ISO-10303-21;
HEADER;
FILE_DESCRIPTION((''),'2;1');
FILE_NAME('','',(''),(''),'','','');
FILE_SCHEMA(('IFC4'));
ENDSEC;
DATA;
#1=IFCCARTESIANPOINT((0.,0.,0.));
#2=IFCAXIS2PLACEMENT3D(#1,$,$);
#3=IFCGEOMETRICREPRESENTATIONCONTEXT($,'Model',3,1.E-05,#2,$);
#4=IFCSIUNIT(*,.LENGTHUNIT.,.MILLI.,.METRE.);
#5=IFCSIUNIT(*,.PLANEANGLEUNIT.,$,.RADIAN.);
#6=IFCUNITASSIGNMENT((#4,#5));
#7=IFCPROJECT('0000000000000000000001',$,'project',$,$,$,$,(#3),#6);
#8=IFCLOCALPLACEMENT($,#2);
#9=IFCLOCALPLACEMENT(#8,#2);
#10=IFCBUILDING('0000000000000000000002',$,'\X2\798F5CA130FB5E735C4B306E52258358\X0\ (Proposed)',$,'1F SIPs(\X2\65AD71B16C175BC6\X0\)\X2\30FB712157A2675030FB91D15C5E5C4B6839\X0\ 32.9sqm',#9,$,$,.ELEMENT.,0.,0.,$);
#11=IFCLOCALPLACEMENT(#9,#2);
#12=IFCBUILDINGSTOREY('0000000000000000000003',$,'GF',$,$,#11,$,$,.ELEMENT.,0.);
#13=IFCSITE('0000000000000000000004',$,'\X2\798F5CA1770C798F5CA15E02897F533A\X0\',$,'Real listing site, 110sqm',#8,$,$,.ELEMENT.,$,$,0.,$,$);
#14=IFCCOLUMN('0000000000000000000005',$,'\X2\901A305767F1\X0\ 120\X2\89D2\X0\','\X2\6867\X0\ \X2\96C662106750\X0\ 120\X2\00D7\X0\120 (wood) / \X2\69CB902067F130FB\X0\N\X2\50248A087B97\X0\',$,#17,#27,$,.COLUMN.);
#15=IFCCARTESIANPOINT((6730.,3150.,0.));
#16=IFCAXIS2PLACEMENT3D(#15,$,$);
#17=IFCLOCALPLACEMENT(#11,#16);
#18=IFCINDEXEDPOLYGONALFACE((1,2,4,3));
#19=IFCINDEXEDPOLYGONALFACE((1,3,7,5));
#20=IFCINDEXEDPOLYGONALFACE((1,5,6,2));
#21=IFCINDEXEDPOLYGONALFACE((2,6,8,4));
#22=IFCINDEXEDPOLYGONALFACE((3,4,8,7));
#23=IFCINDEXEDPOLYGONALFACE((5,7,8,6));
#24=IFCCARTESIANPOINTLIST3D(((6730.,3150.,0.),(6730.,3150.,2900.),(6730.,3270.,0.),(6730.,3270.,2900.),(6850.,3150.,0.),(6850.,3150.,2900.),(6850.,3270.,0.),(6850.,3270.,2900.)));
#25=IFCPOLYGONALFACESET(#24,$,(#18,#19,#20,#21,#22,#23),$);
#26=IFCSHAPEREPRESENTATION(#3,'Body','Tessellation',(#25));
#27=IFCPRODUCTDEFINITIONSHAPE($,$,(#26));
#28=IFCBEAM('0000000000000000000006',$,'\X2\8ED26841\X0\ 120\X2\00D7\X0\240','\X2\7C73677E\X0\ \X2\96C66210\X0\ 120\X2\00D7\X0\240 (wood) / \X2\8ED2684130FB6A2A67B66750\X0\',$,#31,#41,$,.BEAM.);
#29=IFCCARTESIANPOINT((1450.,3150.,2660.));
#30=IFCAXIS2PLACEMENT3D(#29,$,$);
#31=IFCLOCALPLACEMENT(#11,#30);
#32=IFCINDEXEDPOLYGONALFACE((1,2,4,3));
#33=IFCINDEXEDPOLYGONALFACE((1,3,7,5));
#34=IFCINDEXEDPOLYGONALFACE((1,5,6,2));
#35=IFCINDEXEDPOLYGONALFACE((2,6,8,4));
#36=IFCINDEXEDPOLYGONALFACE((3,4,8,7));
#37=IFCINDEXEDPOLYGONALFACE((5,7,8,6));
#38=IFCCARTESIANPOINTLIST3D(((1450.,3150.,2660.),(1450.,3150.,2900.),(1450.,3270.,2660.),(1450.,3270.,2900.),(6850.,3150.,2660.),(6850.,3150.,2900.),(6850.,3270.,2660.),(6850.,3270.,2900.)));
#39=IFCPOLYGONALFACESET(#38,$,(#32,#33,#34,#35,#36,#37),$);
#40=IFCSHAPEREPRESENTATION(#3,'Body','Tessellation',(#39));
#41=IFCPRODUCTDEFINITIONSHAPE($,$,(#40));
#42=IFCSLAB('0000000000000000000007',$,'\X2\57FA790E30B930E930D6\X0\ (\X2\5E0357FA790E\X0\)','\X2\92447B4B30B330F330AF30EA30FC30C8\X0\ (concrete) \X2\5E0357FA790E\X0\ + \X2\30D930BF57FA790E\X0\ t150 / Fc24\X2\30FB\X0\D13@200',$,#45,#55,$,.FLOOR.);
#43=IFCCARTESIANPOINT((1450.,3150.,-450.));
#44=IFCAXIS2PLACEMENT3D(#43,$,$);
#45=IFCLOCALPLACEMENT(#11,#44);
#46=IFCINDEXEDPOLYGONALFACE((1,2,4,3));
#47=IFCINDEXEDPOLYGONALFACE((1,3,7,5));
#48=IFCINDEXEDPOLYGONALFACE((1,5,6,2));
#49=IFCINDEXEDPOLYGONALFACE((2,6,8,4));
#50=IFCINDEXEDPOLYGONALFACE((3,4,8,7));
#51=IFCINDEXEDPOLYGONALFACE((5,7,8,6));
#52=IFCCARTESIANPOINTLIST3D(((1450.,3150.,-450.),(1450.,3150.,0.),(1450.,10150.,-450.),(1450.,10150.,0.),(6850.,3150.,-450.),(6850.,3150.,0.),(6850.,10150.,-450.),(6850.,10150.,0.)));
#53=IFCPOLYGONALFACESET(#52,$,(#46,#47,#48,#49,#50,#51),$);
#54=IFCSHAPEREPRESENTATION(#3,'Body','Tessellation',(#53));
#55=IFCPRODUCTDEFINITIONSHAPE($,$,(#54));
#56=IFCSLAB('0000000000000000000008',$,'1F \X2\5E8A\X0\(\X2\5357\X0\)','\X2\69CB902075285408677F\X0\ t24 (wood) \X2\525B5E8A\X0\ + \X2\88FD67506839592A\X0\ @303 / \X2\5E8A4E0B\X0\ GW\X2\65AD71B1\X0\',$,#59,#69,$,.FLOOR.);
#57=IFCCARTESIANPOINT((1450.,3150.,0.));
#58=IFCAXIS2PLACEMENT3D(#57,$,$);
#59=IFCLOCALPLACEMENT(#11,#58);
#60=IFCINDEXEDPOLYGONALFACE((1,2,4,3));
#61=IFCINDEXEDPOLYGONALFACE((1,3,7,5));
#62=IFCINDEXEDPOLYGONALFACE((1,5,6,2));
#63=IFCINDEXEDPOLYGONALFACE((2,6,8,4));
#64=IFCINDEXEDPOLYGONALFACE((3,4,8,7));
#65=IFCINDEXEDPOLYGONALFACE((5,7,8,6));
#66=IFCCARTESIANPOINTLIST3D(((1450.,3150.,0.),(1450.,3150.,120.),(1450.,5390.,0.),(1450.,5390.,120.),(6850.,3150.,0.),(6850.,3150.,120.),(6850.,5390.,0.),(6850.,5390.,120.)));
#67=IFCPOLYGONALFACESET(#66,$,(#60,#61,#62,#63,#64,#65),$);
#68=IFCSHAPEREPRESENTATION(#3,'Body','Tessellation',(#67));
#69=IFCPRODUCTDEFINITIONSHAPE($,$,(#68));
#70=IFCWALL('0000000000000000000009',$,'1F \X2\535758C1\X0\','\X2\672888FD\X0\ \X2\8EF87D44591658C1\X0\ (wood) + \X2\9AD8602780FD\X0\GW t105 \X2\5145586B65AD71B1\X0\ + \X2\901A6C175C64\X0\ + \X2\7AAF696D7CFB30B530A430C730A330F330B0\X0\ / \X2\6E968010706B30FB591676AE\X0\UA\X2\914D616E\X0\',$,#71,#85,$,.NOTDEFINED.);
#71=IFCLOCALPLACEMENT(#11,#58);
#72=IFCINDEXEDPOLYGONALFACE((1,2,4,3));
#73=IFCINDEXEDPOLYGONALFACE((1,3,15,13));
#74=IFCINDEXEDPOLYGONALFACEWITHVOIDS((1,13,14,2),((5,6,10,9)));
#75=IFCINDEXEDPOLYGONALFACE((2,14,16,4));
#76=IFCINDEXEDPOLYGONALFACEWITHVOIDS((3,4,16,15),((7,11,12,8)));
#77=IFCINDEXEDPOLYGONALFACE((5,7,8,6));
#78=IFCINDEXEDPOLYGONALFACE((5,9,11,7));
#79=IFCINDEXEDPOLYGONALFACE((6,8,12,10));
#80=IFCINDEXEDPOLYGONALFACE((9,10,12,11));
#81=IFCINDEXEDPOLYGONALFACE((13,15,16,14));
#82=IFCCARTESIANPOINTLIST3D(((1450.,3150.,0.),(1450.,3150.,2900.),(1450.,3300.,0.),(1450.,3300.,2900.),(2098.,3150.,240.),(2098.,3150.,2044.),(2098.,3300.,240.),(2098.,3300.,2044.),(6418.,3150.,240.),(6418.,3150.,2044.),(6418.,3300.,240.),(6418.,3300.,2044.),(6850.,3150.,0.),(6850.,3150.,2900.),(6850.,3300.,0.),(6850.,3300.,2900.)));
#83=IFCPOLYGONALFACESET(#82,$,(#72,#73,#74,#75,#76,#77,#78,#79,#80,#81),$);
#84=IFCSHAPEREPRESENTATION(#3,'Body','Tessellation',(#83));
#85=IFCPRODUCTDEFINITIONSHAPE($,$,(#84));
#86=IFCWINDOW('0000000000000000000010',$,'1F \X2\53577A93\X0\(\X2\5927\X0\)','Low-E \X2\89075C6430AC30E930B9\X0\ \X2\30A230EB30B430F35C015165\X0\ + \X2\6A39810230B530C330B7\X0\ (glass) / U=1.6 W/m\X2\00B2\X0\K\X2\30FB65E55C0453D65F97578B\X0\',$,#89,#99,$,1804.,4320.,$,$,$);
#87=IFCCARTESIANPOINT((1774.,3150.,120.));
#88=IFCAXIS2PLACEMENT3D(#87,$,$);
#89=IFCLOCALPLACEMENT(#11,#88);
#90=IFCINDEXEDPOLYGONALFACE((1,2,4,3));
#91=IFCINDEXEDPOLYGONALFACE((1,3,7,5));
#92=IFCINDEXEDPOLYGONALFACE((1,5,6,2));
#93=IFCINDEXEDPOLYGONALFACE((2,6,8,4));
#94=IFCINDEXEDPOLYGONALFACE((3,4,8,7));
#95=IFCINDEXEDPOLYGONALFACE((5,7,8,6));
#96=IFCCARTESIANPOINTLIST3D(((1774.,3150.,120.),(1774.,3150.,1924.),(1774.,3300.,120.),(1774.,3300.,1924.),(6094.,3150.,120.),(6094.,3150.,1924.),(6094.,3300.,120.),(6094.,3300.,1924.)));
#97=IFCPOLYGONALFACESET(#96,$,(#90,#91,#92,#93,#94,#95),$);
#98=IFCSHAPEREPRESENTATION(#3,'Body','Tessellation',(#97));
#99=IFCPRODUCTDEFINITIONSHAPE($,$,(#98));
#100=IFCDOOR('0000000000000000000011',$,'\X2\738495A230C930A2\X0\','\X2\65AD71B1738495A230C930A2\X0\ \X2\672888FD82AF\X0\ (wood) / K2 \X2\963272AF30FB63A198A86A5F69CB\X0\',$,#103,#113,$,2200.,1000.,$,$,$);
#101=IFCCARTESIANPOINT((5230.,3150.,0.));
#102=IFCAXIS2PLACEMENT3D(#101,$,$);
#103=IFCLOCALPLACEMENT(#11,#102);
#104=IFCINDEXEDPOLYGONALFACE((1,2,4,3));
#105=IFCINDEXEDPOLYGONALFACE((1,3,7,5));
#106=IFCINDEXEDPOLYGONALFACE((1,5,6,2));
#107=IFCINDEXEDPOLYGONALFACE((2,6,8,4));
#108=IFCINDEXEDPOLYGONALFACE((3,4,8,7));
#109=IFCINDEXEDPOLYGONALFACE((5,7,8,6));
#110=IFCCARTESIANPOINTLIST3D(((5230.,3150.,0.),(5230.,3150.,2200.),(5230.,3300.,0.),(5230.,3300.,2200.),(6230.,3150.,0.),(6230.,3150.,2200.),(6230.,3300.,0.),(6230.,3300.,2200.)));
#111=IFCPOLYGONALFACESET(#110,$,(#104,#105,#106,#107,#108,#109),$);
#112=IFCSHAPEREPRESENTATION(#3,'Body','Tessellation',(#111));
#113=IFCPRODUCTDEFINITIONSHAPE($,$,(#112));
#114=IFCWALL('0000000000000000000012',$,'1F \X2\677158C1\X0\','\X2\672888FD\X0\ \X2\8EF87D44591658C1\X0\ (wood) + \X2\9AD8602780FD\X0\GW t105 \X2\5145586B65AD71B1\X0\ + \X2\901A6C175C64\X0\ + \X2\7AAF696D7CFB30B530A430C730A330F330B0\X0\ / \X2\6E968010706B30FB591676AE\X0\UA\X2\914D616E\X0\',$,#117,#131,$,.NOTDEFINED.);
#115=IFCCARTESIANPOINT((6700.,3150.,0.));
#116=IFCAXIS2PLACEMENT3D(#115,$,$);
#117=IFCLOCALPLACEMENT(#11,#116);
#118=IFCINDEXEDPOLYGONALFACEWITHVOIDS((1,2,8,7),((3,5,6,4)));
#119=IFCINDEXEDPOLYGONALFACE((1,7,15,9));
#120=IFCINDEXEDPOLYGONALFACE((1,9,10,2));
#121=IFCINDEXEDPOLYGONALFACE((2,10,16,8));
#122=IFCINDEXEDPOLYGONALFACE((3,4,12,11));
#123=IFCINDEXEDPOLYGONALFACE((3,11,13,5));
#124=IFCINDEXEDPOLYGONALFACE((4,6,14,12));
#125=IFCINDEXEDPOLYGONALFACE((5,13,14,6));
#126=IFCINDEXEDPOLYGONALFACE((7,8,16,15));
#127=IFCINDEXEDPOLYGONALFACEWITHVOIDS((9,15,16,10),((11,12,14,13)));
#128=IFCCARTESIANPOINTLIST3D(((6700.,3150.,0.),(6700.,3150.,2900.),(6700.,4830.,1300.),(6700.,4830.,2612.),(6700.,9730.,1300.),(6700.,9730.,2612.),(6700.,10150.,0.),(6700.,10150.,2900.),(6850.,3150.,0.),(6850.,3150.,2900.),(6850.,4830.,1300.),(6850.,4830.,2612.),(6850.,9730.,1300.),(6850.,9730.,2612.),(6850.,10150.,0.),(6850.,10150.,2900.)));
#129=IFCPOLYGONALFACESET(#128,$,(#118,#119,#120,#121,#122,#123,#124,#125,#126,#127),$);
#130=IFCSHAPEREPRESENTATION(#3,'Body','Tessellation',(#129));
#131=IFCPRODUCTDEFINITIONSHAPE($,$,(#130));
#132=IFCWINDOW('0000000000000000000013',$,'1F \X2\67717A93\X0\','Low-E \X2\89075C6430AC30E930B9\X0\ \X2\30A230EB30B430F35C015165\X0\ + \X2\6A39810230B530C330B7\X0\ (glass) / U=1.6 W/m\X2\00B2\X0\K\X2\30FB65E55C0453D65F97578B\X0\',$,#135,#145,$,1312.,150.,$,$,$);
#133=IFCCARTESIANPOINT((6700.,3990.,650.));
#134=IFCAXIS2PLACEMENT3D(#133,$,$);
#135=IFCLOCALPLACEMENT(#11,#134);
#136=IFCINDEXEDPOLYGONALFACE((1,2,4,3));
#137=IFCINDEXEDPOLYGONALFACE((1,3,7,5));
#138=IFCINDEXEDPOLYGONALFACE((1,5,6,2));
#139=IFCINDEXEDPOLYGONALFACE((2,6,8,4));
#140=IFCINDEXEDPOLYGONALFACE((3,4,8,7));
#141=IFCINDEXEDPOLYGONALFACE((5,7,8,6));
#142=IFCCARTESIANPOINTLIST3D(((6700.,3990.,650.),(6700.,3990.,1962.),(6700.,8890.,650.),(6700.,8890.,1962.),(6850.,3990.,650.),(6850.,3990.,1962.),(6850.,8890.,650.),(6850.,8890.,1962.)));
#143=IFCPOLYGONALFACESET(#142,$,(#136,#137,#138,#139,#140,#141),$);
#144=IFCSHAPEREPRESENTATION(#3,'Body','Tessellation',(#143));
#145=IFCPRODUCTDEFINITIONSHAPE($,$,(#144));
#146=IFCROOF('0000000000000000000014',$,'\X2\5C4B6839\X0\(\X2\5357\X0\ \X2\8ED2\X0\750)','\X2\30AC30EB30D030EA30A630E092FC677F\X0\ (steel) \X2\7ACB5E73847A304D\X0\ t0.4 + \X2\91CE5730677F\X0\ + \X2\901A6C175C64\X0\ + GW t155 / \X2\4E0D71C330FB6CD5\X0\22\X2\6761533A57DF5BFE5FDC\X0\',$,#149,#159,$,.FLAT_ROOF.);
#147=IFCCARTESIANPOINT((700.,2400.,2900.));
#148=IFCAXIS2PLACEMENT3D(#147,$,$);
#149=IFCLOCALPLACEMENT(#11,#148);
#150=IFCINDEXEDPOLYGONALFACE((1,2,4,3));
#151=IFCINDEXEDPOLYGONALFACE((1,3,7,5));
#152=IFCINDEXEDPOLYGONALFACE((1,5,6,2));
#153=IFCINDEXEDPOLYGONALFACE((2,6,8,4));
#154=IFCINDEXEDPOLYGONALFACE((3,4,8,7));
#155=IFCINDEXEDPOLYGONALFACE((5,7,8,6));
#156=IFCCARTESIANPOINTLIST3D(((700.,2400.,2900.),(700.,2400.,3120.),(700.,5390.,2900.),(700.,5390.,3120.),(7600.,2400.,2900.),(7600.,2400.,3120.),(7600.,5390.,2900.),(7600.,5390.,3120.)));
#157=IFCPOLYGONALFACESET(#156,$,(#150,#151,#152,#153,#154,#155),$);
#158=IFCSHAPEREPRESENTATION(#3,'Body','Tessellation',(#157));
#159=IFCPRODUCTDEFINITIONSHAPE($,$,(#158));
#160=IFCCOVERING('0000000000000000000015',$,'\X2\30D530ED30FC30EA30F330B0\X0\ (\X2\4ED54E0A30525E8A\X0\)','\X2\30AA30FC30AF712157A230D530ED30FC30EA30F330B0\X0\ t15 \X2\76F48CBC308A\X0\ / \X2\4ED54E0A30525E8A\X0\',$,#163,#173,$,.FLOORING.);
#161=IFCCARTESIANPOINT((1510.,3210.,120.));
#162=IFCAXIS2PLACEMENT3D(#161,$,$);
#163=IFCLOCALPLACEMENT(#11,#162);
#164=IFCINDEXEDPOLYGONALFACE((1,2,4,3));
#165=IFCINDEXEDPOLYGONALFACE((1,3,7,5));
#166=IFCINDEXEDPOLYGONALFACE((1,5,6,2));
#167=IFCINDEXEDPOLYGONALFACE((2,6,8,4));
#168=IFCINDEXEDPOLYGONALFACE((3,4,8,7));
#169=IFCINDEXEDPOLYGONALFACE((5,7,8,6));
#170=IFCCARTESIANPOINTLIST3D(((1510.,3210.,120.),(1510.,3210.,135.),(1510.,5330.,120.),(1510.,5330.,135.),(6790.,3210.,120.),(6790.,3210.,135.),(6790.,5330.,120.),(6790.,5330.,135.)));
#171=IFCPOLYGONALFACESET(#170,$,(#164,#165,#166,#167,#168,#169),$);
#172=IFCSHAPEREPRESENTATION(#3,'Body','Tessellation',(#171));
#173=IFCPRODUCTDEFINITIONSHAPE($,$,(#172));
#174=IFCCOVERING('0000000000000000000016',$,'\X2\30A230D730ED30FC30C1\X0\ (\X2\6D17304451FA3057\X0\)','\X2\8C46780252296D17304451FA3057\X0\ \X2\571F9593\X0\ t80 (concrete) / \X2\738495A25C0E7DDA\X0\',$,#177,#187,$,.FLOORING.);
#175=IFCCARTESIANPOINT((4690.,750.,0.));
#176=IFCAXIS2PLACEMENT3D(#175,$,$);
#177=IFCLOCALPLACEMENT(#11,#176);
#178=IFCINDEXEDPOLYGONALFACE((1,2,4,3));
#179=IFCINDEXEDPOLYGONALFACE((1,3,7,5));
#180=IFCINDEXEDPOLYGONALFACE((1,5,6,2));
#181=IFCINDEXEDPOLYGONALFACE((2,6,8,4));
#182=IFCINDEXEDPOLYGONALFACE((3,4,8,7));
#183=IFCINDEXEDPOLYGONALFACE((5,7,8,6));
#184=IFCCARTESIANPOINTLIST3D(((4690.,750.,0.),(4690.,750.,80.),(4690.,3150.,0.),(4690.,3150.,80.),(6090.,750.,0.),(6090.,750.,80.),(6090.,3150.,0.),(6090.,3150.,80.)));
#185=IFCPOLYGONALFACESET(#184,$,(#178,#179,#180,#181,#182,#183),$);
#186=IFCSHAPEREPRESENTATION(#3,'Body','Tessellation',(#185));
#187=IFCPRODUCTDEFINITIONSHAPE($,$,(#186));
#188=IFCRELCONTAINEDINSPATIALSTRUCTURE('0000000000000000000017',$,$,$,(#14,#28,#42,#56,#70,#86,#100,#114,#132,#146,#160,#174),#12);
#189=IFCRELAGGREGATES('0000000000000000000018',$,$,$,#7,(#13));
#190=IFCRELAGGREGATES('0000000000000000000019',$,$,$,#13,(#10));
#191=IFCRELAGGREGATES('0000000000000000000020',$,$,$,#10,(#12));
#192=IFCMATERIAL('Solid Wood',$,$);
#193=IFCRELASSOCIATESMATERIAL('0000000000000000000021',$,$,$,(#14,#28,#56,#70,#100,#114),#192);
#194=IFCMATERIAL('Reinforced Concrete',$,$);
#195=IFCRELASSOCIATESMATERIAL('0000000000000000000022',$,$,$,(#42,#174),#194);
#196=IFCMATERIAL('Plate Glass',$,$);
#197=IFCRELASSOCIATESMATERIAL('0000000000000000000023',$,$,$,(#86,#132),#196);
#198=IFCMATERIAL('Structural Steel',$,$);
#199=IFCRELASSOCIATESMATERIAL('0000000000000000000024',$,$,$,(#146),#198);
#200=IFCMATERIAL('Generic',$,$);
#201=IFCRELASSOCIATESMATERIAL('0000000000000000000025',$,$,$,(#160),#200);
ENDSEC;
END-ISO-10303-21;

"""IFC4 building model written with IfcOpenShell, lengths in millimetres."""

from ifc_helpers import new_model, si_unit, frame, frame_2d, origin, place, context, project, spatial, rectangle, extrude, material, element, fill, save


model = new_model("IFC4")

# Units and contexts
model_context = context("Model", 3, precision=1e-05, world=origin())
ifc_project = project(units=[si_unit("LENGTHUNIT", "METRE", prefix="MILLI"), si_unit("PLANEANGLEUNIT", "RADIAN")], contexts=[model_context])

# Site, building, storey
site_placement = place(None, origin())
site = spatial("IfcSite", under=ifc_project, at=site_placement, Name="福岡県福岡市西区", ObjectType="Real listing site, 110sqm", CompositionType="ELEMENT", RefElevation=0.0)
building_placement = place(site_placement, origin())
building = spatial("IfcBuilding", under=site, at=building_placement, Name="福岡・平屋の別荘 (Proposed)", ObjectType="1F SIPs(断熱気密)・無垢材・金属屋根 32.9sqm", CompositionType="ELEMENT", ElevationOfRefHeight=0.0, ElevationOfTerrain=0.0)
storey_placement = place(building_placement, origin())
storey = spatial("IfcBuildingStorey", under=building, at=storey_placement, Name="GF", CompositionType="ELEMENT", Elevation=0.0)

# Column
ifc_material_1 = material(Name="Solid Wood")
column_1_placement = place(storey_placement, frame((6730.0, 3150.0, 0.0)))
element("IfcColumn", 1, at=column_1_placement, inside=storey, material=ifc_material_1, Name="通し柱 120角", Description="桧 集成材 120×120 (wood) / 構造柱・N値計算", PredefinedType="COLUMN", context=model_context, shape_type="SweptSolid", body=[
    extrude(rectangle(XDim=120.0, YDim=120.0, at=frame_2d((60.0, 60.0))), frame((6730.0, 3150.0, 0.0)), (0.0, 0.0, 1.0), 2900.0),
])

# Beam
beam_1_placement = place(storey_placement, frame((1450.0, 3150.0, 2660.0)))
element("IfcBeam", 2, at=beam_1_placement, inside=storey, material=ifc_material_1, Name="軒桁 120×240", Description="米松 集成 120×240 (wood) / 軒桁・横架材", PredefinedType="BEAM", context=model_context, shape_type="SweptSolid", body=[
    extrude(rectangle(XDim=5400.0, YDim=120.0, at=frame_2d((2700.0, 60.0))), frame((1450.0, 3150.0, 2660.0)), (0.0, 0.0, 1.0), 240.0),
])

# Slabs
ifc_material_2 = material(Name="Reinforced Concrete")
slab_1_placement = place(storey_placement, frame((1450.0, 3150.0, -450.0)))
element("IfcSlab", 3, at=slab_1_placement, inside=storey, material=ifc_material_2, Name="基礎スラブ (布基礎)", Description="鉄筋コンクリート (concrete) 布基礎 + ベタ基礎 t150 / Fc24・D13@200", PredefinedType="FLOOR", context=model_context, shape_type="SweptSolid", body=[
    extrude(rectangle(XDim=5400.0, YDim=7000.0, at=frame_2d((2700.0, 3500.0))), frame((1450.0, 3150.0, -450.0)), (0.0, 0.0, 1.0), 450.0),
])
slab_2_placement = place(storey_placement, frame((1450.0, 3150.0, 0.0)))
element("IfcSlab", 4, at=slab_2_placement, inside=storey, material=ifc_material_1, Name="1F 床(南)", Description="構造用合板 t24 (wood) 剛床 + 製材根太 @303 / 床下 GW断熱", PredefinedType="FLOOR", context=model_context, shape_type="SweptSolid", body=[
    extrude(rectangle(XDim=5400.0, YDim=2240.0, at=frame_2d((2700.0, 1120.0))), frame((1450.0, 3150.0, 0.0)), (0.0, 0.0, 1.0), 120.0),
])

# Wall, openings, window, door
wall_1_placement = place(storey_placement, frame((1450.0, 3150.0, 0.0)))
wall_1 = element("IfcWall", 5, at=wall_1_placement, inside=storey, material=ifc_material_1, Name="1F 南壁", Description="木製 軸組外壁 (wood) + 高性能GW t105 充填断熱 + 通気層 + 窯業系サイディング / 準耐火・外皮UA配慮", PredefinedType="NOTDEFINED", context=model_context, shape_type="SweptSolid", body=[
    extrude(rectangle(XDim=5400.0, YDim=150.0, at=frame_2d((2700.0, 75.0))), frame((1450.0, 3150.0, 0.0)), (0.0, 0.0, 1.0), 2900.0),
])
opening_1_placement = place(storey_placement, frame((1774.0, 3150.0, 120.0)))
opening_1 = element("IfcOpeningElement", 6, at=opening_1_placement, cuts=wall_1, PredefinedType="NOTDEFINED", context=model_context, shape_type="SweptSolid", body=[
    extrude(rectangle(XDim=4320.0, YDim=150.0, at=frame_2d((2160.0, 75.0))), frame((1774.0, 3150.0, 120.0)), (0.0, 0.0, 1.0), 1804.0),
])
opening_2_placement = place(storey_placement, frame((5230.0, 3150.0, 0.0)))
opening_2 = element("IfcOpeningElement", 7, at=opening_2_placement, cuts=wall_1, PredefinedType="NOTDEFINED", context=model_context, shape_type="SweptSolid", body=[
    extrude(rectangle(XDim=1000.0, YDim=150.0, at=frame_2d((500.0, 75.0))), frame((5230.0, 3150.0, 0.0)), (0.0, 0.0, 1.0), 2200.0),
])
ifc_material_3 = material(Name="Plate Glass")
window_1_placement = place(storey_placement, frame((1774.0, 3150.0, 120.0)))
window_1 = element("IfcWindow", 8, at=window_1_placement, inside=storey, material=ifc_material_3, Name="1F 南窓(大)", Description="Low-E 複層ガラス アルゴン封入 + 樹脂サッシ (glass) / U=1.6 W/m²K・日射取得型", OverallHeight=1804.0, OverallWidth=4320.0, context=model_context, shape_type="SweptSolid", body=[
    extrude(rectangle(XDim=4320.0, YDim=150.0, at=frame_2d((2160.0, 75.0))), frame((1774.0, 3150.0, 120.0)), (0.0, 0.0, 1.0), 1804.0),
])
fill(opening_1, window_1)
door_placement = place(storey_placement, frame((5230.0, 3150.0, 0.0)))
door = element("IfcDoor", 9, at=door_placement, inside=storey, material=ifc_material_1, Name="玄関ドア", Description="断熱玄関ドア 木製芯 (wood) / K2 防犯・採風機構", OverallHeight=2200.0, OverallWidth=1000.0, context=model_context, shape_type="SweptSolid", body=[
    extrude(rectangle(XDim=1000.0, YDim=150.0, at=frame_2d((500.0, 75.0))), frame((5230.0, 3150.0, 0.0)), (0.0, 0.0, 1.0), 2200.0),
])
fill(opening_2, door)

# Wall, opening, window
wall_2_placement = place(storey_placement, frame((6700.0, 3150.0, 0.0)))
wall_2 = element("IfcWall", 10, at=wall_2_placement, inside=storey, material=ifc_material_1, Name="1F 東壁", Description="木製 軸組外壁 (wood) + 高性能GW t105 充填断熱 + 通気層 + 窯業系サイディング / 準耐火・外皮UA配慮", PredefinedType="NOTDEFINED", context=model_context, shape_type="SweptSolid", body=[
    extrude(rectangle(XDim=150.0, YDim=7000.0, at=frame_2d((75.0, 3500.0))), frame((6700.0, 3150.0, 0.0)), (0.0, 0.0, 1.0), 2900.0),
])
opening_3_placement = place(storey_placement, frame((6700.0, 3990.0, 650.0)))
opening_3 = element("IfcOpeningElement", 11, at=opening_3_placement, cuts=wall_2, PredefinedType="NOTDEFINED", context=model_context, shape_type="SweptSolid", body=[
    extrude(rectangle(XDim=150.0, YDim=4900.0, at=frame_2d((75.0, 2450.0))), frame((6700.0, 3990.0, 650.0)), (0.0, 0.0, 1.0), 1312.0),
])
window_2_placement = place(storey_placement, frame((6700.0, 3990.0, 650.0)))
window_2 = element("IfcWindow", 12, at=window_2_placement, inside=storey, material=ifc_material_3, Name="1F 東窓", Description="Low-E 複層ガラス アルゴン封入 + 樹脂サッシ (glass) / U=1.6 W/m²K・日射取得型", OverallHeight=1312.0, OverallWidth=150.0, context=model_context, shape_type="SweptSolid", body=[
    extrude(rectangle(XDim=150.0, YDim=4900.0, at=frame_2d((75.0, 2450.0))), frame((6700.0, 3990.0, 650.0)), (0.0, 0.0, 1.0), 1312.0),
])
fill(opening_3, window_2)

# Roof
ifc_material_4 = material(Name="Structural Steel")
roof_placement = place(storey_placement, frame((700.0, 2400.0, 2900.0)))
element("IfcRoof", 13, at=roof_placement, inside=storey, material=ifc_material_4, Name="屋根(南 軒750)", Description="ガルバリウム鋼板 (steel) 立平葺き t0.4 + 野地板 + 通気層 + GW t155 / 不燃・法22条区域対応", PredefinedType="FLAT_ROOF", context=model_context, shape_type="SweptSolid", body=[
    extrude(rectangle(XDim=6900.0, YDim=2990.0, at=frame_2d((3450.0, 1495.0))), frame((700.0, 2400.0, 2900.0)), (0.0, 0.0, 1.0), 220.0),
])

# Coverings
ifc_material_5 = material(Name="Generic")
covering_1_placement = place(storey_placement, frame((1510.0, 3210.0, 120.0)))
element("IfcCovering", 14, at=covering_1_placement, inside=storey, material=ifc_material_5, Name="フローリング (仕上げ床)", Description="オーク無垢フローリング t15 直貼り / 仕上げ床", PredefinedType="FLOORING", context=model_context, shape_type="SweptSolid", body=[
    extrude(rectangle(XDim=5280.0, YDim=2120.0, at=frame_2d((2640.0, 1060.0))), frame((1510.0, 3210.0, 120.0)), (0.0, 0.0, 1.0), 15.0),
])
covering_2_placement = place(storey_placement, frame((4690.0, 750.0, 0.0)))
element("IfcCovering", 15, at=covering_2_placement, inside=storey, material=ifc_material_2, Name="アプローチ (洗い出し)", Description="豆砂利洗い出し 土間 t80 (concrete) / 玄関導線", PredefinedType="FLOORING", context=model_context, shape_type="SweptSolid", body=[
    extrude(rectangle(XDim=1400.0, YDim=2400.0, at=frame_2d((700.0, 1200.0))), frame((4690.0, 750.0, 0.0)), (0.0, 0.0, 1.0), 80.0),
])

save(model, "model.ifc")
